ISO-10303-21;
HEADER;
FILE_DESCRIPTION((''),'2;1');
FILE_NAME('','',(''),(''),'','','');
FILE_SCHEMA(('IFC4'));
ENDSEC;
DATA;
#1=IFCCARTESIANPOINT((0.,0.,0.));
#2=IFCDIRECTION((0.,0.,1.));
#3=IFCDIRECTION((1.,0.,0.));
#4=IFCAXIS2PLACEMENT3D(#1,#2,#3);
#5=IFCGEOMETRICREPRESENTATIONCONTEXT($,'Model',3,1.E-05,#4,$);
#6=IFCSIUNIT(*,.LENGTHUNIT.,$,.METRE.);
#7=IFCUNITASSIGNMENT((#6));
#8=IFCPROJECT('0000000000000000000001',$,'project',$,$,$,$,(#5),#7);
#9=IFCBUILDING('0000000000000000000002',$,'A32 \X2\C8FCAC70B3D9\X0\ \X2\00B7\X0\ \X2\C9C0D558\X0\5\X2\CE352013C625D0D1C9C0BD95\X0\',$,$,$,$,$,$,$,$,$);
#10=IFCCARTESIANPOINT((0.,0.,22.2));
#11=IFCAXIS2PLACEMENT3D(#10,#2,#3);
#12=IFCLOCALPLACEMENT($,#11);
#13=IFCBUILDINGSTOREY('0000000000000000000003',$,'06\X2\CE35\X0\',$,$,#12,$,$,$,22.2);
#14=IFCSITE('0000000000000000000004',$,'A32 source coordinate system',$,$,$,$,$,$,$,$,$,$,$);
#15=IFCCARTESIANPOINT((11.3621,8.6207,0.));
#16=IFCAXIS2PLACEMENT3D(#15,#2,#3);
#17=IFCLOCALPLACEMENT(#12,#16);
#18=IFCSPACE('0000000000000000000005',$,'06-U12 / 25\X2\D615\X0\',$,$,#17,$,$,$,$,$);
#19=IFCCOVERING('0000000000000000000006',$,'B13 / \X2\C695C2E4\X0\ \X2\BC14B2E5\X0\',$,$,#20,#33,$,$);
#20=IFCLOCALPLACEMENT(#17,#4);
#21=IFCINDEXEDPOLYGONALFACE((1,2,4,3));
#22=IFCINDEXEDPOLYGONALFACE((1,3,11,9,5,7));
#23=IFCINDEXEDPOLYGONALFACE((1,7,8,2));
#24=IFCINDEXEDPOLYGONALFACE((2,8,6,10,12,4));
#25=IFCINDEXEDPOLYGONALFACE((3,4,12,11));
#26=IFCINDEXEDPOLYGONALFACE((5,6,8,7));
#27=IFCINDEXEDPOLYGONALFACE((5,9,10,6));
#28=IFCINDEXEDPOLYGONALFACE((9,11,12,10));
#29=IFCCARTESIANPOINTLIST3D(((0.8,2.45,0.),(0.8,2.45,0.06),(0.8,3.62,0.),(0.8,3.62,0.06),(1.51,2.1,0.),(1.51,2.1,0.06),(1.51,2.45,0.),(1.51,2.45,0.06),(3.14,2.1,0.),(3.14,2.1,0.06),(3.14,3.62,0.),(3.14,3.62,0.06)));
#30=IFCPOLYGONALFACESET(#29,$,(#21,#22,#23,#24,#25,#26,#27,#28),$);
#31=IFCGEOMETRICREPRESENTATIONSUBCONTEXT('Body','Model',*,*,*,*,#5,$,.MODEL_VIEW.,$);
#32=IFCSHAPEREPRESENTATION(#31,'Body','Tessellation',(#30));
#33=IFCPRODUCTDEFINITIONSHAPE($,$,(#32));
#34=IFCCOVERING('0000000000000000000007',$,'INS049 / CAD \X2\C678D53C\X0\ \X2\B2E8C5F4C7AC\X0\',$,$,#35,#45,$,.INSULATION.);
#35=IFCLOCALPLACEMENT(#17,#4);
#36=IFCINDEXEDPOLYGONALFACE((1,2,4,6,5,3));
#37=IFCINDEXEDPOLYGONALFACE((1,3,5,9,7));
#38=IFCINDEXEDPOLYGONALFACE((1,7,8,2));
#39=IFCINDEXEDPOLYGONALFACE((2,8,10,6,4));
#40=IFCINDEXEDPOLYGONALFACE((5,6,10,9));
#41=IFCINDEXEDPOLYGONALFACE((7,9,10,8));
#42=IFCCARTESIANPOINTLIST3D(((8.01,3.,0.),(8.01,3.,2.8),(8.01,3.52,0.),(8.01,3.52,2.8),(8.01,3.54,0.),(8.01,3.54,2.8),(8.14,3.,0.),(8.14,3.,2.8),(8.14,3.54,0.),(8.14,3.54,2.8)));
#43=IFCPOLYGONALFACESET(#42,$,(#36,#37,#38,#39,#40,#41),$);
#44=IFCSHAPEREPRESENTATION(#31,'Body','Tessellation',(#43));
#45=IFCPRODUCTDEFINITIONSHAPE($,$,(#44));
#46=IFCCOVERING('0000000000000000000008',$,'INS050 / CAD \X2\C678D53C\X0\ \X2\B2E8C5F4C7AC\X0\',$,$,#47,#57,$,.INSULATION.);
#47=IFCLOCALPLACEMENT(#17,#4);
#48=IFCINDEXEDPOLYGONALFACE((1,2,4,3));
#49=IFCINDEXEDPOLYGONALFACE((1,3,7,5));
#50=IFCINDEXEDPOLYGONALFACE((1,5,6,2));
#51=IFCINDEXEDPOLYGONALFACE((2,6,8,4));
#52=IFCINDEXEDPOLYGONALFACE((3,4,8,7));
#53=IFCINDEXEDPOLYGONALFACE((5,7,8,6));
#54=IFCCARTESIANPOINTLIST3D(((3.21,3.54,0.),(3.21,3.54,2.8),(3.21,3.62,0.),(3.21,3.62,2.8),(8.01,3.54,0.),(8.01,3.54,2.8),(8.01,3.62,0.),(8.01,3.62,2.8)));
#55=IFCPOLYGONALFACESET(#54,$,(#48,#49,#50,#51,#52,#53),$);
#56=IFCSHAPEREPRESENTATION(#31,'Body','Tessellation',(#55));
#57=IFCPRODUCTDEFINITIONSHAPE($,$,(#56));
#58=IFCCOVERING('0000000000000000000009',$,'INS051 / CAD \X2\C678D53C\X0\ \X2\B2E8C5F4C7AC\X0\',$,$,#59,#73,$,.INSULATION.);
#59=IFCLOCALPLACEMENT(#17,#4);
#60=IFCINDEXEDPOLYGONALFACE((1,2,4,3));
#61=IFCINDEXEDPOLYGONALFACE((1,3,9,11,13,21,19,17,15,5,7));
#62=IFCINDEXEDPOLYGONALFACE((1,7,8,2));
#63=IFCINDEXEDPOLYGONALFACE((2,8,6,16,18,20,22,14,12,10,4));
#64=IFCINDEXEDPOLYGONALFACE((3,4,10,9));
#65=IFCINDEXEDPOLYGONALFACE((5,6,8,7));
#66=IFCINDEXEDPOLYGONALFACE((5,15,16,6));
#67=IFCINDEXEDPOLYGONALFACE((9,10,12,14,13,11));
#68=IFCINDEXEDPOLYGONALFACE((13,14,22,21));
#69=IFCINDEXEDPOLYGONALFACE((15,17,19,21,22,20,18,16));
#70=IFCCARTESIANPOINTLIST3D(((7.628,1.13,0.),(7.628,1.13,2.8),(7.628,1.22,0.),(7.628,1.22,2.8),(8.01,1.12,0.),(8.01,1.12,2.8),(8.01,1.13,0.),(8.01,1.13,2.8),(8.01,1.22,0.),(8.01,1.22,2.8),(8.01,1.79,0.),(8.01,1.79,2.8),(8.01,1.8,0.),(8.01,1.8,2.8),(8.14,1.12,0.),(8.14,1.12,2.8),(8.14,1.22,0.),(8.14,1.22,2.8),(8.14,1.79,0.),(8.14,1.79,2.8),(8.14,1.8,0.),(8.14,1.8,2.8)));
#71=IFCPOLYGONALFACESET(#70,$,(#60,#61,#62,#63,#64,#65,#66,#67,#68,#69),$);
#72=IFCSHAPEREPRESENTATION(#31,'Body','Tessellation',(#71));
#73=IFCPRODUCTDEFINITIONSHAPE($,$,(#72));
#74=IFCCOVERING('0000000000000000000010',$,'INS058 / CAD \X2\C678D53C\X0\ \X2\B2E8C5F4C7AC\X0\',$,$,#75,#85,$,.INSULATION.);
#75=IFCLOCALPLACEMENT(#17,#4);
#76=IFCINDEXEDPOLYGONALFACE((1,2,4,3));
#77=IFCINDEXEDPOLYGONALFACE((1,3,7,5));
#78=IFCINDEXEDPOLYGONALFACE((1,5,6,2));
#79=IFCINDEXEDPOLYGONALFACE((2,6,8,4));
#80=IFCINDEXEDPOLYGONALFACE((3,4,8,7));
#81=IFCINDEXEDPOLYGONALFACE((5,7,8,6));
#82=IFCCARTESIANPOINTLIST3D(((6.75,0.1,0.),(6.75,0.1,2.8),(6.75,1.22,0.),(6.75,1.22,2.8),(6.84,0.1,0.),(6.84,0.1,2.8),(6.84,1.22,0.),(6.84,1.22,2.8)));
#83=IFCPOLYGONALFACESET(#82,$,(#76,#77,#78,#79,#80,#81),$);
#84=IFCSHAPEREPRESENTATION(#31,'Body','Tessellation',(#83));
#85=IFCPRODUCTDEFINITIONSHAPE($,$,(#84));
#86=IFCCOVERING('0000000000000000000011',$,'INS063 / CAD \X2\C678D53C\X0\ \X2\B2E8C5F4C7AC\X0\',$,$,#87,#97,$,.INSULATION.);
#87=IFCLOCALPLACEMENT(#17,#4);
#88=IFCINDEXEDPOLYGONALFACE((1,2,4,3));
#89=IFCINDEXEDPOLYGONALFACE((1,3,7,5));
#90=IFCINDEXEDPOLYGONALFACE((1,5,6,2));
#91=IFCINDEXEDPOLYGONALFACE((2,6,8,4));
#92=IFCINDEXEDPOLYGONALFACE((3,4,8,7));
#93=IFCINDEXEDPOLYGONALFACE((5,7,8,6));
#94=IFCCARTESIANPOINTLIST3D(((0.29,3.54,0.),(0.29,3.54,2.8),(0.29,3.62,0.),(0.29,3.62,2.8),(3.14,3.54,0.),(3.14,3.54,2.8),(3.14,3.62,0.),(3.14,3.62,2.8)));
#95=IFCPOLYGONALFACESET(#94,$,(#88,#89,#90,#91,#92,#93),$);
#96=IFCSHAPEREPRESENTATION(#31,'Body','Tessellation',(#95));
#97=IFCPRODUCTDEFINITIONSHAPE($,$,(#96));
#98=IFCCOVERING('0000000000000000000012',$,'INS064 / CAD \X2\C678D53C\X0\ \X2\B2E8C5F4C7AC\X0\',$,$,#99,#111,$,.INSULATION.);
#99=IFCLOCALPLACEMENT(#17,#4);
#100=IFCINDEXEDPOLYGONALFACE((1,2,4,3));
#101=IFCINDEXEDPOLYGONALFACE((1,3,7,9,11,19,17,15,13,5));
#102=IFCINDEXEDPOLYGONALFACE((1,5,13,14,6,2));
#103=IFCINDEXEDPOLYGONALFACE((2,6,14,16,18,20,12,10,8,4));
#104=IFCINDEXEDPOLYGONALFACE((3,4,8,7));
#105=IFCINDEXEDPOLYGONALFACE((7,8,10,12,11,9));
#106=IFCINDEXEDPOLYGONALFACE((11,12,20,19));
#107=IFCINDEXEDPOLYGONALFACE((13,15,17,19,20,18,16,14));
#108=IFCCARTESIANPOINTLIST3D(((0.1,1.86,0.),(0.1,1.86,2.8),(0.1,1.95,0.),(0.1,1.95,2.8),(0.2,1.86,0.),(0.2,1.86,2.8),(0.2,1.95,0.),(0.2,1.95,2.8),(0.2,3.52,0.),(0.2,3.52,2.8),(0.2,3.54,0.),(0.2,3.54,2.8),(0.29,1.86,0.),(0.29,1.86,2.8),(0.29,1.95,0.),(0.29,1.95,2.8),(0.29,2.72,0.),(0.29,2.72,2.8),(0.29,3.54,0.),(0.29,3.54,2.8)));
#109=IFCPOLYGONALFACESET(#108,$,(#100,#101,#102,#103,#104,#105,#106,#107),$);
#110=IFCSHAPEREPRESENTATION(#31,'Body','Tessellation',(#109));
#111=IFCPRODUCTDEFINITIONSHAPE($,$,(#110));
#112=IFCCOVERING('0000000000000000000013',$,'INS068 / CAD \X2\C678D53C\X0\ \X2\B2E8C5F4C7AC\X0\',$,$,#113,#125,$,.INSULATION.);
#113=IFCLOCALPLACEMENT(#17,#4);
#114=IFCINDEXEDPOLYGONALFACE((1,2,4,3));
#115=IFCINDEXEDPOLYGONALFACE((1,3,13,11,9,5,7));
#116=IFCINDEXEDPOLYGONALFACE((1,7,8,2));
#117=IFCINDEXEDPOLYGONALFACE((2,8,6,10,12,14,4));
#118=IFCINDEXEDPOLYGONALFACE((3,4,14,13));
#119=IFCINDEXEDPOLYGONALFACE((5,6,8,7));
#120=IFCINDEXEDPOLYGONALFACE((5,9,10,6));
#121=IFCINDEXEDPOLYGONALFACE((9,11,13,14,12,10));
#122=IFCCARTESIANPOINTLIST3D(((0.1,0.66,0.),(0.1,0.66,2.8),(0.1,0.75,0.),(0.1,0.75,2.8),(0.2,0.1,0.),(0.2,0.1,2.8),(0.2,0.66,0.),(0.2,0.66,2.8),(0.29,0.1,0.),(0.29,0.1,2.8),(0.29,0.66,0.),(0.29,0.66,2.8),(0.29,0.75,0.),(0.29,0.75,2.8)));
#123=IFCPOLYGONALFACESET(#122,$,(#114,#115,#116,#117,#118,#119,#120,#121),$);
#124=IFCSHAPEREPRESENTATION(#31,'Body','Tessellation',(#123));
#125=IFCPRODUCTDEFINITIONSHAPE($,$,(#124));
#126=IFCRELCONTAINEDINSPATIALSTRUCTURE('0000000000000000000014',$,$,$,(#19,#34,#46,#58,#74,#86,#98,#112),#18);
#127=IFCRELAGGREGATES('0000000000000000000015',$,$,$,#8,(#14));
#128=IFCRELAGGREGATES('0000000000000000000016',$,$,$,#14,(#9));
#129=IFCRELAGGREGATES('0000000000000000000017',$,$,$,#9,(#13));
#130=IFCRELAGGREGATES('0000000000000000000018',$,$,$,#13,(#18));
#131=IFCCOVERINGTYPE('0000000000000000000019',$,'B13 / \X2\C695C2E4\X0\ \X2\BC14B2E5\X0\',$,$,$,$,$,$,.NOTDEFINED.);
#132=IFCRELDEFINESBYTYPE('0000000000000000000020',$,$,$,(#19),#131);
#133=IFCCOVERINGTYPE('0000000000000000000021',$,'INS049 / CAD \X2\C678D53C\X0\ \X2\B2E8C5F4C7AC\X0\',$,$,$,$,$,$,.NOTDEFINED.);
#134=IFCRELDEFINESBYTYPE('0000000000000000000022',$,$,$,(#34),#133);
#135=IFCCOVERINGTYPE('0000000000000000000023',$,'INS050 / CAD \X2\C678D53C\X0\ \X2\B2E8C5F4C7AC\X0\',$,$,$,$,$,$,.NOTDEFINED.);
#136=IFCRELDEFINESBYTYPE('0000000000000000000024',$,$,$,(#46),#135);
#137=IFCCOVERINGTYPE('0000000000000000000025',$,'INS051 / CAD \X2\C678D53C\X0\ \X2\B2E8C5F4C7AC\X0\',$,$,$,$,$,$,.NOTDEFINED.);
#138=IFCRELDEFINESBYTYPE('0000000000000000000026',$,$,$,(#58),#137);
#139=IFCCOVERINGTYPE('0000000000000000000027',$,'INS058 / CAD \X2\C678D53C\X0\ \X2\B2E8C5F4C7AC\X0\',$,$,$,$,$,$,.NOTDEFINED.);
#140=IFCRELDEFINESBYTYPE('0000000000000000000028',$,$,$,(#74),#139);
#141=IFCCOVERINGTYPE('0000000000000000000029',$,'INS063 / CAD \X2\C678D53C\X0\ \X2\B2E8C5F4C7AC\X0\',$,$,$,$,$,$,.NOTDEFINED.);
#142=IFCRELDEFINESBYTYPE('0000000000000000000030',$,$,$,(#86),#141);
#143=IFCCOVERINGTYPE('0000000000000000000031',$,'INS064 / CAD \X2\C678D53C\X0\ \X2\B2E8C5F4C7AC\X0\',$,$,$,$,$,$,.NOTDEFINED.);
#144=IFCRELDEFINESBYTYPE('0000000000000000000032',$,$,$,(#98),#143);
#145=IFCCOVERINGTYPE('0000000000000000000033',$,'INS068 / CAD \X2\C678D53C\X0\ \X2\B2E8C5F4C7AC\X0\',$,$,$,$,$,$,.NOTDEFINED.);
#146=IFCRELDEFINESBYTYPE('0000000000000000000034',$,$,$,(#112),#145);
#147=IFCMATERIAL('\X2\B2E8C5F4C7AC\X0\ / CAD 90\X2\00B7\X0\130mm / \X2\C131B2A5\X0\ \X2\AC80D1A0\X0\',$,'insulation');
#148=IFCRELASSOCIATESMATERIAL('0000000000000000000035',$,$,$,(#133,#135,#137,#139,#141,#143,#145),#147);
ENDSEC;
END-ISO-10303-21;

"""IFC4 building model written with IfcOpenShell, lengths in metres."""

from ifc_helpers import new_model, si_unit, frame, origin, origin_with_axes, place, context, subcontext, project, spatial, polyline, outline, extrude, source, transform, mapped, material, type_object, type_shapes, element, save


model = new_model("IFC4")

# Units and contexts
model_context = context("Model", 3, precision=1e-05, world=origin_with_axes())
body_context = subcontext(model_context, "Body", "Model", "MODEL_VIEW")
ifc_project = project(units=[si_unit("LENGTHUNIT", "METRE")], contexts=[model_context])

# Site, building, storey
storey_placement = place(None, frame((0.0, 0.0, 22.2), z_axis=(0.0, 0.0, 1.0), x_axis=(1.0, 0.0, 0.0)))
space_1_placement = place(storey_placement, frame((11.3621, 8.6207, 0.0), z_axis=(0.0, 0.0, 1.0), x_axis=(1.0, 0.0, 0.0)))
site = spatial("IfcSite", under=ifc_project, Name="A32 source coordinate system")
building = spatial("IfcBuilding", under=site, Name="A32 주거동 · 지하5층–옥탑지붕")
storey = spatial("IfcBuildingStorey", under=building, at=storey_placement, Name="06층", Elevation=22.2)

# Shared definitions
space_1 = spatial("IfcSpace", under=storey, at=space_1_placement, Name="06-U12 / 25형")

# Coverings
covering_type_1 = type_object("IfcCoveringType", Name="B13 / 욕실 바닥", PredefinedType="NOTDEFINED")
shared_shape_1 = source(origin(), body_context, "Body", "SweptSolid", [
    extrude(outline(polyline([(3.14, 2.1), (1.51, 2.1), (1.51, 2.45), (0.8, 2.45), (0.8, 3.62), (3.14, 3.62), (3.14, 2.1)])), origin(), (0.0, 0.0, 1.0), 0.06),
])
type_shapes(covering_type_1, [shared_shape_1])
covering_1_placement = place(space_1_placement, origin_with_axes())
element("IfcCovering", 1, at=covering_1_placement, inside=space_1, type_object=covering_type_1, Name="B13 / 욕실 바닥", context=body_context, shape_type="MappedRepresentation", body=[
    mapped(shared_shape_1, transform((0.0, 0.0, 0.0), scale=1.0)),
])
ifc_material = material(Name="단열재 / CAD 90·130mm / 성능 검토", Category="insulation")
covering_type_2 = type_object("IfcCoveringType", Name="INS049 / CAD 외피 단열재", PredefinedType="NOTDEFINED", material=ifc_material)
shared_shape_2 = source(origin(), body_context, "Body", "SweptSolid", [
    extrude(outline(polyline([(8.01, 3.54), (8.14, 3.54), (8.14, 3.0), (8.01, 3.0), (8.01, 3.52), (8.01, 3.54)])), origin(), (0.0, 0.0, 1.0), 2.8),
])
type_shapes(covering_type_2, [shared_shape_2])
covering_2_placement = place(space_1_placement, origin_with_axes())
element("IfcCovering", 2, at=covering_2_placement, inside=space_1, type_object=covering_type_2, Name="INS049 / CAD 외피 단열재", PredefinedType="INSULATION", context=body_context, shape_type="MappedRepresentation", body=[
    mapped(shared_shape_2, transform((0.0, 0.0, 0.0), scale=1.0)),
])
covering_type_3 = type_object("IfcCoveringType", Name="INS050 / CAD 외피 단열재", PredefinedType="NOTDEFINED", material=ifc_material)
shared_shape_3 = source(origin(), body_context, "Body", "SweptSolid", [
    extrude(outline(polyline([(8.01, 3.54), (3.21, 3.54), (3.21, 3.62), (8.01, 3.62), (8.01, 3.54)])), origin(), (0.0, 0.0, 1.0), 2.8),
])
type_shapes(covering_type_3, [shared_shape_3])
covering_3_placement = place(space_1_placement, origin_with_axes())
element("IfcCovering", 3, at=covering_3_placement, inside=space_1, type_object=covering_type_3, Name="INS050 / CAD 외피 단열재", PredefinedType="INSULATION", context=body_context, shape_type="MappedRepresentation", body=[
    mapped(shared_shape_3, transform((0.0, 0.0, 0.0), scale=1.0)),
])
covering_type_4 = type_object("IfcCoveringType", Name="INS051 / CAD 외피 단열재", PredefinedType="NOTDEFINED", material=ifc_material)
shared_shape_4 = source(origin(), body_context, "Body", "SweptSolid", [
    extrude(outline(polyline([(8.14, 1.12), (8.01, 1.12), (8.01, 1.13), (7.628, 1.13), (7.628, 1.22), (8.01, 1.22), (8.01, 1.79), (8.01, 1.8), (8.14, 1.8), (8.14, 1.79), (8.14, 1.22), (8.14, 1.12)])), origin(), (0.0, 0.0, 1.0), 2.8),
])
type_shapes(covering_type_4, [shared_shape_4])
covering_4_placement = place(space_1_placement, origin_with_axes())
element("IfcCovering", 4, at=covering_4_placement, inside=space_1, type_object=covering_type_4, Name="INS051 / CAD 외피 단열재", PredefinedType="INSULATION", context=body_context, shape_type="MappedRepresentation", body=[
    mapped(shared_shape_4, transform((0.0, 0.0, 0.0), scale=1.0)),
])
covering_type_5 = type_object("IfcCoveringType", Name="INS058 / CAD 외피 단열재", PredefinedType="NOTDEFINED", material=ifc_material)
shared_shape_5 = source(origin(), body_context, "Body", "SweptSolid", [
    extrude(outline(polyline([(6.75, 0.1), (6.75, 1.22), (6.84, 1.22), (6.84, 0.1), (6.75, 0.1)])), origin(), (0.0, 0.0, 1.0), 2.8),
])
type_shapes(covering_type_5, [shared_shape_5])
covering_5_placement = place(space_1_placement, origin_with_axes())
element("IfcCovering", 5, at=covering_5_placement, inside=space_1, type_object=covering_type_5, Name="INS058 / CAD 외피 단열재", PredefinedType="INSULATION", context=body_context, shape_type="MappedRepresentation", body=[
    mapped(shared_shape_5, transform((0.0, 0.0, 0.0), scale=1.0)),
])
covering_type_6 = type_object("IfcCoveringType", Name="INS063 / CAD 외피 단열재", PredefinedType="NOTDEFINED", material=ifc_material)
shared_shape_6 = source(origin(), body_context, "Body", "SweptSolid", [
    extrude(outline(polyline([(0.29, 3.54), (0.29, 3.62), (3.14, 3.62), (3.14, 3.54), (0.29, 3.54)])), origin(), (0.0, 0.0, 1.0), 2.8),
])
type_shapes(covering_type_6, [shared_shape_6])
covering_6_placement = place(space_1_placement, origin_with_axes())
element("IfcCovering", 6, at=covering_6_placement, inside=space_1, type_object=covering_type_6, Name="INS063 / CAD 외피 단열재", PredefinedType="INSULATION", context=body_context, shape_type="MappedRepresentation", body=[
    mapped(shared_shape_6, transform((0.0, 0.0, 0.0), scale=1.0)),
])
covering_type_7 = type_object("IfcCoveringType", Name="INS064 / CAD 외피 단열재", PredefinedType="NOTDEFINED", material=ifc_material)
shared_shape_7 = source(origin(), body_context, "Body", "SweptSolid", [
    extrude(outline(polyline([(0.1, 1.86), (0.1, 1.95), (0.2, 1.95), (0.2, 3.52), (0.2, 3.54), (0.29, 3.54), (0.29, 2.72), (0.29, 1.95), (0.29, 1.86), (0.2, 1.86), (0.1, 1.86)])), origin(), (0.0, 0.0, 1.0), 2.8),
])
type_shapes(covering_type_7, [shared_shape_7])
covering_7_placement = place(space_1_placement, origin_with_axes())
element("IfcCovering", 7, at=covering_7_placement, inside=space_1, type_object=covering_type_7, Name="INS064 / CAD 외피 단열재", PredefinedType="INSULATION", context=body_context, shape_type="MappedRepresentation", body=[
    mapped(shared_shape_7, transform((0.0, 0.0, 0.0), scale=1.0)),
])
covering_type_8 = type_object("IfcCoveringType", Name="INS068 / CAD 외피 단열재", PredefinedType="NOTDEFINED", material=ifc_material)
shared_shape_8 = source(origin(), body_context, "Body", "SweptSolid", [
    extrude(outline(polyline([(0.2, 0.1), (0.2, 0.66), (0.1, 0.66), (0.1, 0.75), (0.29, 0.75), (0.29, 0.66), (0.29, 0.1), (0.2, 0.1)])), origin(), (0.0, 0.0, 1.0), 2.8),
])
type_shapes(covering_type_8, [shared_shape_8])
covering_8_placement = place(space_1_placement, origin_with_axes())
element("IfcCovering", 8, at=covering_8_placement, inside=space_1, type_object=covering_type_8, Name="INS068 / CAD 외피 단열재", PredefinedType="INSULATION", context=body_context, shape_type="MappedRepresentation", body=[
    mapped(shared_shape_8, transform((0.0, 0.0, 0.0), scale=1.0)),
])

save(model, "model.ifc")
